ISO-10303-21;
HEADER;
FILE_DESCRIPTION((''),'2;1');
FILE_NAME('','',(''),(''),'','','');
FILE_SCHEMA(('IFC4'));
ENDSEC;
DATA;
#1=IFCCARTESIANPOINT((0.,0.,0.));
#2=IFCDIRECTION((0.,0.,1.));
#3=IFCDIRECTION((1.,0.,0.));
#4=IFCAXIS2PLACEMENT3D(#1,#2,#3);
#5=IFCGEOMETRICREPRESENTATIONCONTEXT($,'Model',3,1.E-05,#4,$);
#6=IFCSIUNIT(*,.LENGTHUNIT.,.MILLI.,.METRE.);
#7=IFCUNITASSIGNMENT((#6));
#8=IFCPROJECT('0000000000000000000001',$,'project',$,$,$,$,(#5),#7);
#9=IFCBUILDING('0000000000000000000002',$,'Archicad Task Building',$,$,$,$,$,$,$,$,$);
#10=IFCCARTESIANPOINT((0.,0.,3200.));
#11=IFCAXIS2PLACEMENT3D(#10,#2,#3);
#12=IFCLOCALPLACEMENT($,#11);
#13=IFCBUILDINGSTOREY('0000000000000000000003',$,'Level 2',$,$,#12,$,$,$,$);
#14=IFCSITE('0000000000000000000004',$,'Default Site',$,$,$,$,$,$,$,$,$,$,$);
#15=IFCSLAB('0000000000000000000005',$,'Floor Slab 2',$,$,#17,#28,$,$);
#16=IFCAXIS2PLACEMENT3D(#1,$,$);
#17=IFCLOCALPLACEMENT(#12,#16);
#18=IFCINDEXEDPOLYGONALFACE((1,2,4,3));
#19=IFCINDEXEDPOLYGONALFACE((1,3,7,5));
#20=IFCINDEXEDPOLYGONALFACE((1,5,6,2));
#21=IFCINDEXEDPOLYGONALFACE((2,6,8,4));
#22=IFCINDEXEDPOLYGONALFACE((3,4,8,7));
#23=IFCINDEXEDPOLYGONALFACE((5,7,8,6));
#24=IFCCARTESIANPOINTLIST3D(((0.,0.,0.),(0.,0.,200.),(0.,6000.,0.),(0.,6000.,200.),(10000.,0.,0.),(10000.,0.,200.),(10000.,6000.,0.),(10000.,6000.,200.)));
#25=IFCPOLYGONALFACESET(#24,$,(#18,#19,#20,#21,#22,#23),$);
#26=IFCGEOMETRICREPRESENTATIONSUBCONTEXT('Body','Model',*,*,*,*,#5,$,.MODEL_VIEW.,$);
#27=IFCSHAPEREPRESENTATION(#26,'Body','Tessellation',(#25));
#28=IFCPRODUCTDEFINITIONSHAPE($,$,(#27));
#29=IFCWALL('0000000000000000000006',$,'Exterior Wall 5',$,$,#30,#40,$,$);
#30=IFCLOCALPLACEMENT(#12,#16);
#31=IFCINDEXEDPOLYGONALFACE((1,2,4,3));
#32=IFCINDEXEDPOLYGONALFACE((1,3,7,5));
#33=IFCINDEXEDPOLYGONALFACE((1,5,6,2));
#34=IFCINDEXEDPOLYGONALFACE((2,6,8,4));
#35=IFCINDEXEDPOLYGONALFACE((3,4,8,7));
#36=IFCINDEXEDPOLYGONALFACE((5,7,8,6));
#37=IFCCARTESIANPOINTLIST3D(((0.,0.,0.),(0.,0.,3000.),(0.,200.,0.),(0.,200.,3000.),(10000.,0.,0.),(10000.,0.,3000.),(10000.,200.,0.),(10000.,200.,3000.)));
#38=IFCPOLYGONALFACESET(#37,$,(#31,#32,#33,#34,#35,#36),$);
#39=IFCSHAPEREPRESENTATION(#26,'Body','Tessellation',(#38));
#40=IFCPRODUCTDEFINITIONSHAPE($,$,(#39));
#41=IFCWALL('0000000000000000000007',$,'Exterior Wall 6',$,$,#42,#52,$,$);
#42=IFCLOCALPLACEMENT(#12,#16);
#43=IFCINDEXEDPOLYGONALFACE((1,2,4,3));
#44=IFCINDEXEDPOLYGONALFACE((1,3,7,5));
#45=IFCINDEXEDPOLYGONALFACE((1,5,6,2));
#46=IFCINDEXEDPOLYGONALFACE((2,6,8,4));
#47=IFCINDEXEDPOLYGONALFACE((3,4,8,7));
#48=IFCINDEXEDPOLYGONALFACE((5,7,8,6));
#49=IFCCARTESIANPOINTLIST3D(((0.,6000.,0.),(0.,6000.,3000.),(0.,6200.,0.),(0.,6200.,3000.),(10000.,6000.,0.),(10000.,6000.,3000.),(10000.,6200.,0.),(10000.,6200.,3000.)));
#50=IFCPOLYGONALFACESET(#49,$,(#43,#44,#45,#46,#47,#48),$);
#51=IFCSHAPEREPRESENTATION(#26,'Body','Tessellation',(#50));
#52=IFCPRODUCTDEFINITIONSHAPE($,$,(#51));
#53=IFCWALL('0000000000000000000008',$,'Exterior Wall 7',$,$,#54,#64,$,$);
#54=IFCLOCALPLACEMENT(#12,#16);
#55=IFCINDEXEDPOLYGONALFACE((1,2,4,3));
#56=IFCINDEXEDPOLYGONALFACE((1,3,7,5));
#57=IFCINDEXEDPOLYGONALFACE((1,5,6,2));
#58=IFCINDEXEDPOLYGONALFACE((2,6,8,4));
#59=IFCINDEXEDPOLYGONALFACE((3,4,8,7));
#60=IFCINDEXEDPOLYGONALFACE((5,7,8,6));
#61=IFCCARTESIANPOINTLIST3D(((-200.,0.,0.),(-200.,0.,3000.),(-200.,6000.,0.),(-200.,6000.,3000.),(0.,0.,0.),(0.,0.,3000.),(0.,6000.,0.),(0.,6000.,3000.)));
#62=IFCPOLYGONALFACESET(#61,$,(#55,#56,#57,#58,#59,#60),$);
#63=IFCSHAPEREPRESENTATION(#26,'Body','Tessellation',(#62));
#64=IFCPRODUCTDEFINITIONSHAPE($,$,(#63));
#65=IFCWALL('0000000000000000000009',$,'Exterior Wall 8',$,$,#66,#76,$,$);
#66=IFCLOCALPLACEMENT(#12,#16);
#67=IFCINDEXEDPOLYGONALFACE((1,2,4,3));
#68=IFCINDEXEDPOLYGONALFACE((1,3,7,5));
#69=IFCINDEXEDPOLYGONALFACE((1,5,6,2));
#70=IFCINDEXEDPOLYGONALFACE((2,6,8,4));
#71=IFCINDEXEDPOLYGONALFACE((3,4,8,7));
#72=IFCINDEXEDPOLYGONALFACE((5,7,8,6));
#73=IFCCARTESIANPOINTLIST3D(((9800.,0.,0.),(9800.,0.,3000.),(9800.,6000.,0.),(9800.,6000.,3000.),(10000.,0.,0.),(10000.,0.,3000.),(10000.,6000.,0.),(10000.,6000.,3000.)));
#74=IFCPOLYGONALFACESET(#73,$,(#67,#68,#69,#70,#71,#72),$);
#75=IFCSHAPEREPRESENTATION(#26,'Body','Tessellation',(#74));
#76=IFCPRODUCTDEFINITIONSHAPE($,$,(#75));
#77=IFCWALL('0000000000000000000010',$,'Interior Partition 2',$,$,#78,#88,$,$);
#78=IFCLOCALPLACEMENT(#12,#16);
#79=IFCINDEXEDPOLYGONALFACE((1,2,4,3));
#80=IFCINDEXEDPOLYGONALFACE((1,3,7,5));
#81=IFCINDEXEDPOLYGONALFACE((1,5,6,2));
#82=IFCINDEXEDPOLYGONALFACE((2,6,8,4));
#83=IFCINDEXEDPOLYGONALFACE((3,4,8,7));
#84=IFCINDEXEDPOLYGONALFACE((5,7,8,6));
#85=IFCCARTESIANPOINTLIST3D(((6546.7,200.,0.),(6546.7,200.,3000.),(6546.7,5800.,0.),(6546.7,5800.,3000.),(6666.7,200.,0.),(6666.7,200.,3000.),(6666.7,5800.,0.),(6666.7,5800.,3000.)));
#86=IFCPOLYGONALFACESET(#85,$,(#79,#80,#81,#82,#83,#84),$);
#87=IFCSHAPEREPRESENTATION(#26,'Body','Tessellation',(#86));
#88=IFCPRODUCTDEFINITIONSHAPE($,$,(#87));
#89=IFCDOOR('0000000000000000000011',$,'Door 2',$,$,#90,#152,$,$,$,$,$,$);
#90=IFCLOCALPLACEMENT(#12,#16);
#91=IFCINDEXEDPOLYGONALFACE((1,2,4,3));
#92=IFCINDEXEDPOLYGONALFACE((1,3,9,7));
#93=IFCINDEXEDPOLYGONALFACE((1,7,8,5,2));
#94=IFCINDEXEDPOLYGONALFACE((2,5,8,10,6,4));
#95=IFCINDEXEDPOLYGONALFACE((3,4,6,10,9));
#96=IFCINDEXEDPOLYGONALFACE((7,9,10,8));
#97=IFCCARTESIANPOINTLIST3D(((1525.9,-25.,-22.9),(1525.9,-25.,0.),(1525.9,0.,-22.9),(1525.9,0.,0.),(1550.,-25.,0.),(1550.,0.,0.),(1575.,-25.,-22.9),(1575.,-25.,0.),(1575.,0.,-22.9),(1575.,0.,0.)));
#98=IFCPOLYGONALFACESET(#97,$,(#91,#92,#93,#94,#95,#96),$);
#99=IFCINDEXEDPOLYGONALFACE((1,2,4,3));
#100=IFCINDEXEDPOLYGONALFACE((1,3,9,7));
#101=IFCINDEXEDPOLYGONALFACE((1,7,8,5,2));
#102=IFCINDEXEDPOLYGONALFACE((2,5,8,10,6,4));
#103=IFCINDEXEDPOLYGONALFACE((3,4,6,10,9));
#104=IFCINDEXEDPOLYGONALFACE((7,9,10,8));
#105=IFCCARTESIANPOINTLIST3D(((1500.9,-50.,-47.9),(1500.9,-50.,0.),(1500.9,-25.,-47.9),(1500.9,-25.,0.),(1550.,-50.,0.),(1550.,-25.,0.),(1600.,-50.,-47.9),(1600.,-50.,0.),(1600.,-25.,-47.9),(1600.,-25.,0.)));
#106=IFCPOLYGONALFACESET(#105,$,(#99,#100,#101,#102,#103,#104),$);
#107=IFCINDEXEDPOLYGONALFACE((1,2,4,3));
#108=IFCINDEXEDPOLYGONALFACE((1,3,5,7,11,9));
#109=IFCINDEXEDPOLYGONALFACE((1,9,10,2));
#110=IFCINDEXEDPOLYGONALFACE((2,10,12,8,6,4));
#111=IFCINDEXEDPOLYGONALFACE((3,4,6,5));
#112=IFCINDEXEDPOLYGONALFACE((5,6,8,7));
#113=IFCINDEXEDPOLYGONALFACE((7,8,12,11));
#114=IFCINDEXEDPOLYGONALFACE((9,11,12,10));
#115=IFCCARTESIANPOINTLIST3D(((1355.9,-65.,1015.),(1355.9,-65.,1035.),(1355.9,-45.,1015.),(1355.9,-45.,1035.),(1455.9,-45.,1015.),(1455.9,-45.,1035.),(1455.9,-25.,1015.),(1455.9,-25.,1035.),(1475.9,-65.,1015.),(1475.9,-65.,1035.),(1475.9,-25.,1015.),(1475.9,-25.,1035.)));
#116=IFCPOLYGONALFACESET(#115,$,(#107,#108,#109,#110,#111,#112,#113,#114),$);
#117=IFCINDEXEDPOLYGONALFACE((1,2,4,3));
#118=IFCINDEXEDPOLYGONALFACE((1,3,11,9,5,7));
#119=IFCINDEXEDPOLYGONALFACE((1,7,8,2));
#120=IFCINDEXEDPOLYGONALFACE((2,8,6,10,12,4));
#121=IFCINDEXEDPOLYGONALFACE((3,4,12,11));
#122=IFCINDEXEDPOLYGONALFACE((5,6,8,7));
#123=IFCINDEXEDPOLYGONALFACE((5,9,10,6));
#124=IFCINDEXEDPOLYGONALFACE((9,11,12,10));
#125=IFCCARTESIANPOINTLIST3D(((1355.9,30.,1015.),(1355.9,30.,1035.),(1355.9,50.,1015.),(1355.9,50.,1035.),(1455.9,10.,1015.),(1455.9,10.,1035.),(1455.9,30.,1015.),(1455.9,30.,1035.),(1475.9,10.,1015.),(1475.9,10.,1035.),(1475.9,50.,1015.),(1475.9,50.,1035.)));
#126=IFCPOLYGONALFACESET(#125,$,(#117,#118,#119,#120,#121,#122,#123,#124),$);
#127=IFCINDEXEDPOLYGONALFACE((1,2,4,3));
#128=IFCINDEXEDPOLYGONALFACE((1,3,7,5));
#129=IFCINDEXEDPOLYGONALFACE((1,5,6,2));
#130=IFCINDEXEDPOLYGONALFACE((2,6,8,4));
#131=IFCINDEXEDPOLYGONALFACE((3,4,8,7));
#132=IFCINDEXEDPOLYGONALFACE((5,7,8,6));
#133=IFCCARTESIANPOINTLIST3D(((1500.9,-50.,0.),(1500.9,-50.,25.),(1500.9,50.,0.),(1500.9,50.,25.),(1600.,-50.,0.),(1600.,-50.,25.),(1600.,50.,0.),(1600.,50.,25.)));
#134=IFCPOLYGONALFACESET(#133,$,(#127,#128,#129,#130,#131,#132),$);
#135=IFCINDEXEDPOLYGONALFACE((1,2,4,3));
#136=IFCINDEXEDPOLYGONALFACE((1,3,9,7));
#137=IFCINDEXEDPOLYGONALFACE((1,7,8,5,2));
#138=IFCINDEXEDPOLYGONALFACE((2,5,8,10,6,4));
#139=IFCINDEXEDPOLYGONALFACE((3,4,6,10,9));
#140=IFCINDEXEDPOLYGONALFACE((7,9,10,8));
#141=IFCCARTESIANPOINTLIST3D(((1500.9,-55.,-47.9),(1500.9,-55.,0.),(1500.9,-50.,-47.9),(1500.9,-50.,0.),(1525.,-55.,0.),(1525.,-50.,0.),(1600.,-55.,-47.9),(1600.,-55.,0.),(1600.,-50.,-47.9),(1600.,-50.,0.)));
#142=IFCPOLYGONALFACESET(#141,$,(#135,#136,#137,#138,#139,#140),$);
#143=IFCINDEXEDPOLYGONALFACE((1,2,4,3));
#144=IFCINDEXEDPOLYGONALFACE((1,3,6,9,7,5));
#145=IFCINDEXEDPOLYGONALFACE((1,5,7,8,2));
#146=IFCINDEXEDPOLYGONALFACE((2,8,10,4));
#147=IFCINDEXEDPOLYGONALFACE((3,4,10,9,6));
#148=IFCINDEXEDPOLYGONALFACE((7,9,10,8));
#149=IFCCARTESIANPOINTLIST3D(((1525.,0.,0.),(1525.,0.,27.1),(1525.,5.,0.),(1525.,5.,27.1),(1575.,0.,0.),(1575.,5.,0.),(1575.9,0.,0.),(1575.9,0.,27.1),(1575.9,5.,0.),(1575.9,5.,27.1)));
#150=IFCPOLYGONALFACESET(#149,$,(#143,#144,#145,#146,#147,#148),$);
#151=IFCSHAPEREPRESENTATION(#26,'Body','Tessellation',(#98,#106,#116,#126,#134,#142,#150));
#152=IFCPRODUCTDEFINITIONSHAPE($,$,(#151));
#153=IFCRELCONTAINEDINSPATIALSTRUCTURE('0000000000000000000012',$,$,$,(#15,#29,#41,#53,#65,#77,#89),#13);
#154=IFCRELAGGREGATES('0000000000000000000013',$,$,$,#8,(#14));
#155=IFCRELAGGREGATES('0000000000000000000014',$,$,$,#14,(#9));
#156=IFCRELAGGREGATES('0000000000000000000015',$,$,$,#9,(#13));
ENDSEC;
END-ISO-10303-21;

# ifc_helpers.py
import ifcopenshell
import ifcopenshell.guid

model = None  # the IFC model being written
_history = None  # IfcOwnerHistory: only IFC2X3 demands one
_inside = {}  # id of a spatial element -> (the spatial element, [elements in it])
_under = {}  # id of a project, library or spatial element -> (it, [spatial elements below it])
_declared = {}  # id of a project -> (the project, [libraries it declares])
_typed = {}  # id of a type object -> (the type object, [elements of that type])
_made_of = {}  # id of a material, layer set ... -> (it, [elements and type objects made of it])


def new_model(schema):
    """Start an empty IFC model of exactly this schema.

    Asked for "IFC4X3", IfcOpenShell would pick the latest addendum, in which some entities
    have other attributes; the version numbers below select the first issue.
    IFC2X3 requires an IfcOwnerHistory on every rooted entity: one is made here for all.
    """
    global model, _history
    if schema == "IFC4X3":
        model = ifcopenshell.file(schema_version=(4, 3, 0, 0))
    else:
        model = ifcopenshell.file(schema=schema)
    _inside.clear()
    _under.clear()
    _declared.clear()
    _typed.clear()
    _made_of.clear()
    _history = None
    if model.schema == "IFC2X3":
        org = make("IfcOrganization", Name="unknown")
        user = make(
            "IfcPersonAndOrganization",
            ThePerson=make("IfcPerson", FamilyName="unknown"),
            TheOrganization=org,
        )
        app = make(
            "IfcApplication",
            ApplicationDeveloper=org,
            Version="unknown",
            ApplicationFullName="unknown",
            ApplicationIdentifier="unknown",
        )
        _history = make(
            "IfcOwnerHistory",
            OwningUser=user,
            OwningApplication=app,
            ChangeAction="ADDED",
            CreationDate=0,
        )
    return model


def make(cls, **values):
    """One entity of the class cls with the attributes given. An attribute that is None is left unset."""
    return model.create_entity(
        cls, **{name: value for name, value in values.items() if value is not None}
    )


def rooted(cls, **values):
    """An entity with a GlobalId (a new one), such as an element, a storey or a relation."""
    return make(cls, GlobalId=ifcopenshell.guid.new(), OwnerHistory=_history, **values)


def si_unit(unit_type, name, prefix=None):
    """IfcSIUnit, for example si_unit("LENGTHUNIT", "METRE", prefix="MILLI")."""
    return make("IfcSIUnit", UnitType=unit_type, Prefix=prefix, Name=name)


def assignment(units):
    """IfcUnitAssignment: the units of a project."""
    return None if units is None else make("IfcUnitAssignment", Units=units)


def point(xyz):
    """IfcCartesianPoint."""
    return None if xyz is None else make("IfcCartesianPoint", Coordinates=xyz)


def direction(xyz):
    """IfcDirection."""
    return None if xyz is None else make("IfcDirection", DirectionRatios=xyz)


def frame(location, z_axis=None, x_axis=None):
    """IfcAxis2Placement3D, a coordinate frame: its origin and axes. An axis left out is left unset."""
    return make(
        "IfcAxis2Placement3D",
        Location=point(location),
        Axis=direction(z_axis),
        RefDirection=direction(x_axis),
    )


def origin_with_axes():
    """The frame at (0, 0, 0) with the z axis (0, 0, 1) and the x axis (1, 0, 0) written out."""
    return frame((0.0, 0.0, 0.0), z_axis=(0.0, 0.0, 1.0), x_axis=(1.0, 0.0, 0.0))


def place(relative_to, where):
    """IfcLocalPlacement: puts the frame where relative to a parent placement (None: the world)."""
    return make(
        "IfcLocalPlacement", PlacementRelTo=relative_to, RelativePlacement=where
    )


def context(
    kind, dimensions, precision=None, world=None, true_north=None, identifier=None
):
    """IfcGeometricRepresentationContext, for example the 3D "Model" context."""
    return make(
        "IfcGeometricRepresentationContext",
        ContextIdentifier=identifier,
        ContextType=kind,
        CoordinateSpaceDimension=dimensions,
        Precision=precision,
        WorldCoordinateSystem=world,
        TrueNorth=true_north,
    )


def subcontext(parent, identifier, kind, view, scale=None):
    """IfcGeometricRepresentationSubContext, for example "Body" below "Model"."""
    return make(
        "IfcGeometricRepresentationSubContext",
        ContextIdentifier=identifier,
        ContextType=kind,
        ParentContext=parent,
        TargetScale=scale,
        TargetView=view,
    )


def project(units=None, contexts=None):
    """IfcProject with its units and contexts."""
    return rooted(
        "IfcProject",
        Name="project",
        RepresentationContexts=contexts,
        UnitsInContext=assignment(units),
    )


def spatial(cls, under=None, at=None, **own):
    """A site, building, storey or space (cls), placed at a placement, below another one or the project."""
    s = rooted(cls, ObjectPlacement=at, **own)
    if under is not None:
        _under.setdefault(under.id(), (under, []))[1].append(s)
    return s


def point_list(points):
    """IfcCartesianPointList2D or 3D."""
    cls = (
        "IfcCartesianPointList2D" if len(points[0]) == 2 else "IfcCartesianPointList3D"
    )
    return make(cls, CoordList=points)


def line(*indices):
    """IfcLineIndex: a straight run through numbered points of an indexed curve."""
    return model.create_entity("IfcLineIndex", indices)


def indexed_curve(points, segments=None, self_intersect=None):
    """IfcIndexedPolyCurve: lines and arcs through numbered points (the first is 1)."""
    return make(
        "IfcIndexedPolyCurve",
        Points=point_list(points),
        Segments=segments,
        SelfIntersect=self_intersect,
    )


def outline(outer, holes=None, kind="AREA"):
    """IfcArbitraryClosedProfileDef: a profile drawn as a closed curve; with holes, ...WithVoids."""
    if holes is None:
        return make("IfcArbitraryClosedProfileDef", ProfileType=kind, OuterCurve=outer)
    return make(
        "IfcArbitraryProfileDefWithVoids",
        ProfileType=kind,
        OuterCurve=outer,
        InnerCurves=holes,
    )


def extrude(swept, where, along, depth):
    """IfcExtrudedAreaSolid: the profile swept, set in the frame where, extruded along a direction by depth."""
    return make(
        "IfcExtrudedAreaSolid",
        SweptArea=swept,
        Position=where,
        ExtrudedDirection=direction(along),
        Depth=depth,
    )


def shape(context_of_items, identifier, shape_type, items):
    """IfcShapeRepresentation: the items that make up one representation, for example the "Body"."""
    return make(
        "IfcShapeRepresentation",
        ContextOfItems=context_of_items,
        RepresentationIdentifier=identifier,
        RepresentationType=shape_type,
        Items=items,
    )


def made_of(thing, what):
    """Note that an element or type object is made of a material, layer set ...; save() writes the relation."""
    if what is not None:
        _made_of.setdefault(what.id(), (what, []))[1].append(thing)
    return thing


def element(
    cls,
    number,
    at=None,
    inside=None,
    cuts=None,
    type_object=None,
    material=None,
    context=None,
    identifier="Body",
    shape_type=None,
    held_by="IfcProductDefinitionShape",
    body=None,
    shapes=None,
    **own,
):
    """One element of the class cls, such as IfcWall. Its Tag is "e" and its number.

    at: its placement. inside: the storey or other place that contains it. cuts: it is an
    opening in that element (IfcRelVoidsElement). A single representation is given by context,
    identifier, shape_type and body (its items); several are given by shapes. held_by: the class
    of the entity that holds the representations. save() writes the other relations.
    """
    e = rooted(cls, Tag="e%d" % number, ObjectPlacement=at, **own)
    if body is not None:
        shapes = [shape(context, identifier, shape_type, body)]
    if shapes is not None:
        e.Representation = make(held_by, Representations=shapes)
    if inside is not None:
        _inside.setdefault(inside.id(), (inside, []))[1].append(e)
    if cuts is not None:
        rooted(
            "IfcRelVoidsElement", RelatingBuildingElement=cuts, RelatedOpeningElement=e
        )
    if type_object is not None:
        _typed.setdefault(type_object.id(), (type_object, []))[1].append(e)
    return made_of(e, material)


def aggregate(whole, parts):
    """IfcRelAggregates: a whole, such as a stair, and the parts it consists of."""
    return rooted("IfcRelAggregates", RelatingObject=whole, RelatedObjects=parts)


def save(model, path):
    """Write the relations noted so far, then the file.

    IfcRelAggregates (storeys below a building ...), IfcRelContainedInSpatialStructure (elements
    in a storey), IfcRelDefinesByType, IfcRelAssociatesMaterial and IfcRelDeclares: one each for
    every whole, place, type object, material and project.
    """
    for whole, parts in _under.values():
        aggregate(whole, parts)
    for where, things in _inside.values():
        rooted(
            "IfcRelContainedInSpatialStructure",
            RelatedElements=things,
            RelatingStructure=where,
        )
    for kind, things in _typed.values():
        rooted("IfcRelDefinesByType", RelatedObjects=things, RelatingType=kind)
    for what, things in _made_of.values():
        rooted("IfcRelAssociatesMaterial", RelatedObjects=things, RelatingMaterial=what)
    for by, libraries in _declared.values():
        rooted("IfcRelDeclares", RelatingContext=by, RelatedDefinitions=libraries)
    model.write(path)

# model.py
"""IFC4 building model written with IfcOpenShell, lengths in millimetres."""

from ifc_helpers import new_model, si_unit, frame, origin_with_axes, place, context, subcontext, project, spatial, line, indexed_curve, outline, extrude, element, save


model = new_model("IFC4")

# Units and contexts
model_context = context("Model", 3, precision=1e-05, world=origin_with_axes())
body_context = subcontext(model_context, "Body", "Model", "MODEL_VIEW")
ifc_project = project(units=[si_unit("LENGTHUNIT", "METRE", prefix="MILLI")], contexts=[model_context])

# Site, building, storey
site = spatial("IfcSite", under=ifc_project, Name="Default Site")
building = spatial("IfcBuilding", under=site, Name="Archicad Task Building")
storey_placement = place(None, frame((0.0, 0.0, 3200.0), z_axis=(0.0, 0.0, 1.0), x_axis=(1.0, 0.0, 0.0)))
storey = spatial("IfcBuildingStorey", under=building, at=storey_placement, Name="Level 2")

# Slab
slab_placement = place(storey_placement, origin_with_axes())
element("IfcSlab", 1, at=slab_placement, inside=storey, Name="Floor Slab 2", context=body_context, shape_type="SweptSolid", body=[
    extrude(outline(indexed_curve([(0.0, 0.0), (10000.0, 0.0), (10000.0, 6000.0), (0.0, 6000.0), (0.0, 0.0)])), None, (0.0, 0.0, 1.0), 200.0),
])

# Walls
for number, where, z_axis, x_axis, name in (
    (2, (0.0, 0.0, 0.0), (0.0, 0.0, 1.0), (1.0, 0.0, 0.0), "Exterior Wall 5"),
    (3, (0.0, 6000.0, 0.0), (0.0, 0.0, 1.0), (1.0, 0.0, 0.0), "Exterior Wall 6"),
):
    element("IfcWall", number, at=place(storey_placement, frame(where, z_axis=z_axis, x_axis=x_axis)), inside=storey, Name=name, context=body_context, shape_type="SweptSolid", body=[
        extrude(outline(indexed_curve([(0.0, 0.0), (0.0, 200.0), (10000.0, 200.0), (10000.0, 0.0), (0.0, 0.0)], self_intersect=False)), origin_with_axes(), (0.0, 0.0, 1.0), 3000.0),
    ])
for number, where, z_axis, x_axis, name in (
    (4, (0.0, 0.0, 0.0), (0.0, 0.0, 1.0), (0.0, 1.0, 0.0), "Exterior Wall 7"),
    (5, (10000.0, 0.0, 0.0), (0.0, 0.0, 1.0), (0.0, 1.0, 0.0), "Exterior Wall 8"),
):
    element("IfcWall", number, at=place(storey_placement, frame(where, z_axis=z_axis, x_axis=x_axis)), inside=storey, Name=name, context=body_context, shape_type="SweptSolid", body=[
        extrude(outline(indexed_curve([(0.0, 0.0), (0.0, 200.0), (6000.0, 200.0), (6000.0, 0.0), (0.0, 0.0)], self_intersect=False)), origin_with_axes(), (0.0, 0.0, 1.0), 3000.0),
    ])
wall_placement = place(storey_placement, frame((6666.7, 200.0, 0.0), z_axis=(0.0, 0.0, 1.0), x_axis=(0.0, 1.0, 0.0)))
element("IfcWall", 6, at=wall_placement, inside=storey, Name="Interior Partition 2", context=body_context, shape_type="SweptSolid", body=[
    extrude(outline(indexed_curve([(0.0, 0.0), (0.0, 120.0), (5600.0, 120.0), (5600.0, 0.0), (0.0, 0.0)], self_intersect=False)), origin_with_axes(), (0.0, 0.0, 1.0), 3000.0),
])

# Door
door_1_placement = place(storey_placement, frame((1550.0, -50.0, 0.0), z_axis=(0.0, 0.0, 1.0), x_axis=(1.0, 0.0, 0.0)))
element("IfcDoor", 7, at=door_1_placement, inside=storey, Name="Door 2", context=body_context, shape_type="SweptSolid", body=[
    extrude(outline(indexed_curve([(0.0, 0.0), (0.0, 2.1), (0.9, 2.1), (0.9, 0.0), (-24.1, 0.0), (-24.1, -22.9), (25.0, -22.9), (25.0, 0.0)], segments=[line(1, 2, 3, 4, 5, 6, 7, 8, 1)])), frame((0.0, 25.0, 0.0), z_axis=(0.0, -1.0, 0.0), x_axis=(1.0, 0.0, 0.0)), (0.0, 0.0, -1.0), 25.0),
    extrude(outline(indexed_curve([(0.0, 0.0), (0.0, 2.1), (0.9, 2.1), (0.9, 0.0), (-49.1, 0.0), (-49.1, -47.9), (50.0, -47.9), (50.0, 0.0)], segments=[line(1, 2, 3, 4, 5, 6, 7, 8, 1)])), frame((0.0, 0.0, 0.0), z_axis=(0.0, -1.0, 0.0), x_axis=(1.0, 0.0, 0.0)), (0.0, 0.0, -1.0), 25.0),
    extrude(outline(indexed_curve([(0.0, 0.0), (-49.1, 0.0), (-49.1, 35.0), (0.0, 35.0)], segments=[line(1, 2, 3, 4, 1)])), frame((25.0, 25.0, 25.0), z_axis=(0.0, 0.0, 1.0), x_axis=(1.0, 0.0, 0.0)), (0.0, 0.0, 1.0), -47.9),
    extrude(outline(indexed_curve([(0.0, 0.0), (0.0, -40.0), (-120.0, -40.0), (-120.0, -20.0), (-20.0, -20.0), (-20.0, 0.0)], segments=[line(1, 2, 3, 4, 5, 6, 1)])), frame((-74.1, 25.0, 1015.0), z_axis=(0.0, 0.0, 1.0), x_axis=(1.0, 0.0, 0.0)), (0.0, 0.0, 1.0), 20.0),
    extrude(outline(indexed_curve([(0.0, 0.0), (0.0, 40.0), (-120.0, 40.0), (-120.0, 20.0), (-20.0, 20.0), (-20.0, 0.0)], segments=[line(1, 2, 3, 4, 5, 6, 1)])), frame((-74.1, 60.0, 1015.0), z_axis=(0.0, 0.0, 1.0), x_axis=(1.0, 0.0, 0.0)), (0.0, 0.0, 1.0), 20.0),
    extrude(outline(indexed_curve([(0.0, 0.0), (-99.1, 0.0), (-99.1, 100.0), (0.0, 100.0)], segments=[line(1, 2, 3, 4, 1)])), frame((50.0, 0.0, 0.0), z_axis=(0.0, 0.0, 1.0), x_axis=(1.0, 0.0, 0.0)), (0.0, 0.0, 1.0), 25.0),
    extrude(outline(indexed_curve([(0.0, 0.0), (0.0, 27.1), (50.9, 27.1), (50.9, 0.0), (-24.1, 0.0), (-24.1, -47.9), (75.0, -47.9), (75.0, 0.0)], segments=[line(1, 2, 3, 4, 5, 6, 7, 8, 1)])), frame((-25.0, -5.0, 0.0), z_axis=(0.0, -1.0, 0.0), x_axis=(1.0, 0.0, 0.0)), (0.0, 0.0, -1.0), 5.0),
    extrude(outline(indexed_curve([(0.0, 0.0), (0.0, 27.1), (50.9, 27.1), (50.9, 0.0), (0.9, 0.0), (0.9, -22.9), (50.0, -22.9), (50.0, 0.0)], segments=[line(1, 2, 3, 4, 5, 6, 7, 8, 1)])), frame((-25.0, 50.0, 0.0), z_axis=(0.0, -1.0, 0.0), x_axis=(1.0, 0.0, 0.0)), (0.0, 0.0, -1.0), 5.0),
])

save(model, "model.ifc")
